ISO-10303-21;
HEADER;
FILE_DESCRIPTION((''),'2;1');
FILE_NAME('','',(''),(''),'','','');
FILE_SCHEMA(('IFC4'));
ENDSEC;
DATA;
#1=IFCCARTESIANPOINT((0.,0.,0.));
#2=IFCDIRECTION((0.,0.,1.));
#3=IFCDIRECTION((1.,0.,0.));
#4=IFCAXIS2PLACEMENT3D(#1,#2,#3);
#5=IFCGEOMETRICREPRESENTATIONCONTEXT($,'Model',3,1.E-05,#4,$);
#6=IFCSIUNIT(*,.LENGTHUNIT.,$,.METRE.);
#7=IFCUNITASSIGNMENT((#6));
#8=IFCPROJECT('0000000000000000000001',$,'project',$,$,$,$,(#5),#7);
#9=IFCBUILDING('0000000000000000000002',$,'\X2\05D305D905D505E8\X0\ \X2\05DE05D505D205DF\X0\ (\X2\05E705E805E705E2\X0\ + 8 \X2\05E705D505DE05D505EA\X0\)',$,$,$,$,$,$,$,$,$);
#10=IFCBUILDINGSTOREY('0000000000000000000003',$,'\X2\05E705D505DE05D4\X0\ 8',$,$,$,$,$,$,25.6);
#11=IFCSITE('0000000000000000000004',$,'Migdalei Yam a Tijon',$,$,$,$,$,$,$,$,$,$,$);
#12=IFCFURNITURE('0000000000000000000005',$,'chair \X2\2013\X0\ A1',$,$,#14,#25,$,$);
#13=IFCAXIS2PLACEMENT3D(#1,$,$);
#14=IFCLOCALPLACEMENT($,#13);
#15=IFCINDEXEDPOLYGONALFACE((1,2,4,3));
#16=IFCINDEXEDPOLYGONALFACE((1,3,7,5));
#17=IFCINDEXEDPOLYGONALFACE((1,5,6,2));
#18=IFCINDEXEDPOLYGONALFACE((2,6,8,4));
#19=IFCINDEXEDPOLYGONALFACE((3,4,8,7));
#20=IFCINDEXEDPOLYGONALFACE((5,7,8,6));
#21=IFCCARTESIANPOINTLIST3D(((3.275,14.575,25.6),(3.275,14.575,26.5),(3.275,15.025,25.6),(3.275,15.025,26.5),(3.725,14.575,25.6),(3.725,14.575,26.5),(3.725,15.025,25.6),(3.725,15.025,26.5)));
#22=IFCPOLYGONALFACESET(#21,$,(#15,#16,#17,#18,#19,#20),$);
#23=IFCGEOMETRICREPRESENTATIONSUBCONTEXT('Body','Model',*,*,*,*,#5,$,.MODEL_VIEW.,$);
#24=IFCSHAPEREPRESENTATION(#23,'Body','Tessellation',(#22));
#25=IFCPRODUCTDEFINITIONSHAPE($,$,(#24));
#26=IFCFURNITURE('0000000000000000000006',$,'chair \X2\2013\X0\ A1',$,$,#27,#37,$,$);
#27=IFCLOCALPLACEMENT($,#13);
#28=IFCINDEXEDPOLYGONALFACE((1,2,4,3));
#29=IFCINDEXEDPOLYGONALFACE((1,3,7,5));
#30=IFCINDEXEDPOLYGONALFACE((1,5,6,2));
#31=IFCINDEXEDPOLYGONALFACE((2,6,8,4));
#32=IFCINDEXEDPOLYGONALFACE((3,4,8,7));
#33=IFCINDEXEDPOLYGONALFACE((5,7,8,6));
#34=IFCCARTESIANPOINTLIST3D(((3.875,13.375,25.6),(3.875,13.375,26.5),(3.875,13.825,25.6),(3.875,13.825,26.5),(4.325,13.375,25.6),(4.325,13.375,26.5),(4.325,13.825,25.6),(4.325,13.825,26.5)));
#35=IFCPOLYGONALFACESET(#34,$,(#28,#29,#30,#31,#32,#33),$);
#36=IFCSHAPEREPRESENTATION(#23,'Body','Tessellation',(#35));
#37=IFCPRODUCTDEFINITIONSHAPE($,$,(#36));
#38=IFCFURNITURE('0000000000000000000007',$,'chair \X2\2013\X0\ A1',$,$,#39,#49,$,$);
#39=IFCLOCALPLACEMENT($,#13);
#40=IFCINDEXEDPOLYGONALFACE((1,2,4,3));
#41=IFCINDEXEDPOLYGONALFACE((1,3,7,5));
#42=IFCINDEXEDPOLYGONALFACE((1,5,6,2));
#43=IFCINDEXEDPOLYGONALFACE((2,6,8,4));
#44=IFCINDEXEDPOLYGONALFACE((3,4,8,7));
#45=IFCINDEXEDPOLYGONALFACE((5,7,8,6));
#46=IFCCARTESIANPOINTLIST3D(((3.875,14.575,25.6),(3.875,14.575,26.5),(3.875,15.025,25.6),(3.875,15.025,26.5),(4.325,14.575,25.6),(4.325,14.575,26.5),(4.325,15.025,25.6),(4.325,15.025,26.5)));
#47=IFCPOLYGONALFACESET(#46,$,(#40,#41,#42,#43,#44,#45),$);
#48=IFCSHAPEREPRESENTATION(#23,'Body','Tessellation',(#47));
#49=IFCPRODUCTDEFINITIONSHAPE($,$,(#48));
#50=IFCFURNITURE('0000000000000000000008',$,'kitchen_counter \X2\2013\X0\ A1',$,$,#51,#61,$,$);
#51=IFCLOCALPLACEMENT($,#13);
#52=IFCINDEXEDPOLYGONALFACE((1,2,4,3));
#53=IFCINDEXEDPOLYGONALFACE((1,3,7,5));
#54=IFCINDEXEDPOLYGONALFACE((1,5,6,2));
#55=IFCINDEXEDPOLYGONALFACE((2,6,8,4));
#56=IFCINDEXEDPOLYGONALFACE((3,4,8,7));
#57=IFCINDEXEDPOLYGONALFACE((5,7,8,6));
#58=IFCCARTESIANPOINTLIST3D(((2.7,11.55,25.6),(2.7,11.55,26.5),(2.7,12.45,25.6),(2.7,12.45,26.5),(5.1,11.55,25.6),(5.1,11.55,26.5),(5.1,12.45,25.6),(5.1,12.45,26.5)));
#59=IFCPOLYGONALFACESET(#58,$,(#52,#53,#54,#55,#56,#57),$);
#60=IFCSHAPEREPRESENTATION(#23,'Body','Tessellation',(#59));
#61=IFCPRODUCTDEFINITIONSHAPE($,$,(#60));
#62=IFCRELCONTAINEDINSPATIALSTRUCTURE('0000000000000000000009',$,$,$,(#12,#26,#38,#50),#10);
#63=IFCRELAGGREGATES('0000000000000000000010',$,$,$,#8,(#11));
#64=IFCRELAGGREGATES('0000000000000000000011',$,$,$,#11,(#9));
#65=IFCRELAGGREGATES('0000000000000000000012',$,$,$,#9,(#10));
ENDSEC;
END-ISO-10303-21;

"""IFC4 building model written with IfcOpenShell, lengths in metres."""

from ifc_helpers import new_model, si_unit, frame, origin_with_axes, context, subcontext, project, spatial, line, indexed_curve, outline, extrude, element, save


model = new_model("IFC4")

# Units and contexts
model_context = context("Model", 3, precision=1e-05, world=origin_with_axes())
body_context = subcontext(model_context, "Body", "Model", "MODEL_VIEW")
ifc_project = project(units=[si_unit("LENGTHUNIT", "METRE")], contexts=[model_context])

# Site, building, storey
site = spatial("IfcSite", under=ifc_project, Name="Migdalei Yam a Tijon")
building = spatial("IfcBuilding", under=site, Name="דיור מוגן (קרקע + 8 קומות)")
storey = spatial("IfcBuildingStorey", under=building, Name="קומה 8", Elevation=25.6)

# Furniture
element("IfcFurniture", 1, inside=storey, Name="chair – A1", context=body_context, shape_type="SweptSolid", body=[
    extrude(outline(indexed_curve([(0.0, 0.0), (0.45, 0.0), (0.45, 0.45), (0.0, 0.45)], segments=[line(1, 2, 3, 4, 1)])), frame((3.275, 14.575, 25.6), z_axis=(0.0, 0.0, 1.0), x_axis=(1.0, 0.0, 0.0)), (0.0, 0.0, 1.0), 0.9),
])
element("IfcFurniture", 2, inside=storey, Name="chair – A1", context=body_context, shape_type="SweptSolid", body=[
    extrude(outline(indexed_curve([(0.0, 0.0), (0.45, 0.0), (0.45, 0.45), (0.0, 0.45)], segments=[line(1, 2, 3, 4, 1)])), frame((3.875, 13.375, 25.6), z_axis=(0.0, 0.0, 1.0), x_axis=(1.0, 0.0, 0.0)), (0.0, 0.0, 1.0), 0.9),
])
element("IfcFurniture", 3, inside=storey, Name="chair – A1", context=body_context, shape_type="SweptSolid", body=[
    extrude(outline(indexed_curve([(0.0, 0.0), (0.45, 0.0), (0.45, 0.45), (0.0, 0.45)], segments=[line(1, 2, 3, 4, 1)])), frame((3.875, 14.575, 25.6), z_axis=(0.0, 0.0, 1.0), x_axis=(1.0, 0.0, 0.0)), (0.0, 0.0, 1.0), 0.9),
])
element("IfcFurniture", 4, inside=storey, Name="kitchen_counter – A1", context=body_context, shape_type="SweptSolid", body=[
    extrude(outline(indexed_curve([(0.0, 0.0), (2.4, 0.0), (2.4, 0.9), (0.0, 0.9)], segments=[line(1, 2, 3, 4, 1)])), frame((2.7, 11.55, 25.6), z_axis=(0.0, 0.0, 1.0), x_axis=(1.0, 0.0, 0.0)), (0.0, 0.0, 1.0), 0.9),
])

save(model, "model.ifc")
